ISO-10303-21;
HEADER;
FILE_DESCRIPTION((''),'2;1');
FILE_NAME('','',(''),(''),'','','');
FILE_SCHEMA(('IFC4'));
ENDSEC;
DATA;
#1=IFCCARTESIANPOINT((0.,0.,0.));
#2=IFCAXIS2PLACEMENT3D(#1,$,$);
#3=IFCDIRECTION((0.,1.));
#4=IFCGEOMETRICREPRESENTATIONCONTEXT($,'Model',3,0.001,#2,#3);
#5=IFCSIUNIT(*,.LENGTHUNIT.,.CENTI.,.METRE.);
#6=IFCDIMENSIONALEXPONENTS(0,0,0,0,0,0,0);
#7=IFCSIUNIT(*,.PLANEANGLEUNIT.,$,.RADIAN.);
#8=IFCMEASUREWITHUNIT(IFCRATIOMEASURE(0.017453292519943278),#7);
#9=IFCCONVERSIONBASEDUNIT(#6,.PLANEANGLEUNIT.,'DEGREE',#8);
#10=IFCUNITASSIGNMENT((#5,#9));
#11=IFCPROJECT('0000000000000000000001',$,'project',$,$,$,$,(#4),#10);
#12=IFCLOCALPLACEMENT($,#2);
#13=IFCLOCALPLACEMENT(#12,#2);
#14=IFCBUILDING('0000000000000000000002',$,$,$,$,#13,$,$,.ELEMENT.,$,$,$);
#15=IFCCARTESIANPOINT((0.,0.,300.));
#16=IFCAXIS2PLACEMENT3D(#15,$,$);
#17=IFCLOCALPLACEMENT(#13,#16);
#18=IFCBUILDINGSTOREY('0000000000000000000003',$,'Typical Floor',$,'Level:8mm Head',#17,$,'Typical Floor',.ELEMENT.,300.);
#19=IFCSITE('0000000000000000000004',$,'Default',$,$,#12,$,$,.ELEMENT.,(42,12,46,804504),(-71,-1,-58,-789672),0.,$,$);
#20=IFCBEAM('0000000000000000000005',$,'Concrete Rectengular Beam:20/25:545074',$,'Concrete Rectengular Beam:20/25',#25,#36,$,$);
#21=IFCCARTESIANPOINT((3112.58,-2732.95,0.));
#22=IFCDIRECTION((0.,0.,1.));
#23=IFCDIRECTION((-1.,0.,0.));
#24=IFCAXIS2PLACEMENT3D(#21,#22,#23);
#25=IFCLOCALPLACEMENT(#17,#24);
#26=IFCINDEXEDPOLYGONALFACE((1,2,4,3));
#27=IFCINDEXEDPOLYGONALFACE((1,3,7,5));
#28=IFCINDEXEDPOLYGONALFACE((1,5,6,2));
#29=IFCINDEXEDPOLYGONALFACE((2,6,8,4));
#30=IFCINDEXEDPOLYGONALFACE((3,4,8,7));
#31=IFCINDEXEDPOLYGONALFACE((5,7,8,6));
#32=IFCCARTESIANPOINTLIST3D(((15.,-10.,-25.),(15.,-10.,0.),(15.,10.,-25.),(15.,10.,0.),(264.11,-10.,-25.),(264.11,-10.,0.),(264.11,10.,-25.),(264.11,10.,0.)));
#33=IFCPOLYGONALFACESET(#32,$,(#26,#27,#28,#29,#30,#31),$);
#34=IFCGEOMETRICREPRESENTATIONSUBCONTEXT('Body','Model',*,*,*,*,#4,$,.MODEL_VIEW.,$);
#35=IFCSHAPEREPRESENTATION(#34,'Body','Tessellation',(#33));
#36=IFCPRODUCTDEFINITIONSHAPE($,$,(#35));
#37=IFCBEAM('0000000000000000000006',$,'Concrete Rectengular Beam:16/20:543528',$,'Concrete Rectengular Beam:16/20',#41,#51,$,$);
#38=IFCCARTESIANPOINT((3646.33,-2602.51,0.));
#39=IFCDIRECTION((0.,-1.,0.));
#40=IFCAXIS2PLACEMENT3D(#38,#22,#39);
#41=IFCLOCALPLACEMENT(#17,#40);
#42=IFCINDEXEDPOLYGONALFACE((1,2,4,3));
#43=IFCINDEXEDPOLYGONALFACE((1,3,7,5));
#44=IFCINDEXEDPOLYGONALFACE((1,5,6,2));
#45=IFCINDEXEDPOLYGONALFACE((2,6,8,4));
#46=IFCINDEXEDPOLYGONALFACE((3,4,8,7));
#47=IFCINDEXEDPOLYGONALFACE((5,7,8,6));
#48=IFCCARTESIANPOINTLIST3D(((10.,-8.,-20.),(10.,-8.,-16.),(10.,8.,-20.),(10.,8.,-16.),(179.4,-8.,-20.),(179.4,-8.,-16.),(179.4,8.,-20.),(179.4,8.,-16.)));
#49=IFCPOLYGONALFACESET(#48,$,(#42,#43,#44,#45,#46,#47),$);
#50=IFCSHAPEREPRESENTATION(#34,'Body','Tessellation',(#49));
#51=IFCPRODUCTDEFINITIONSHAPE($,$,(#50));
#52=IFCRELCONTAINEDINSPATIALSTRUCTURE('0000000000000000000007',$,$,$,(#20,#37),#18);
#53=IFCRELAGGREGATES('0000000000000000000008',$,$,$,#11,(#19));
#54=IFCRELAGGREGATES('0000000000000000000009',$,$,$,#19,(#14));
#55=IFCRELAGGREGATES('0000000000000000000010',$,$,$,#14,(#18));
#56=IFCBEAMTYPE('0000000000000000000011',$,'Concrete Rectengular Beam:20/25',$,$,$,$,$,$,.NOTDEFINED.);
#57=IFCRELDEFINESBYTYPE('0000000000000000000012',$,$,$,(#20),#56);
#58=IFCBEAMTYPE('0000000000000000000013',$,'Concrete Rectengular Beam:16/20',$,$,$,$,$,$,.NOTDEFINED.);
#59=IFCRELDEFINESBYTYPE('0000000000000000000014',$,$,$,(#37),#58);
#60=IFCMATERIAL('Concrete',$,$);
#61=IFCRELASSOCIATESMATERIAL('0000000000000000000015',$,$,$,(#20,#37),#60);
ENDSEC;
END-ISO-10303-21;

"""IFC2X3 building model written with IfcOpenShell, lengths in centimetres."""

from ifc_helpers import new_model, entity, si_unit, converted_unit, direction, frame, frame_2d, origin, place, context, subcontext, project, spatial, rectangle, extrude, material, type_object, element, save


model = new_model("IFC2X3")

# Units and contexts
model_context = context("Model", 3, precision=0.001, world=origin(), true_north=direction((0.0, 1.0)))
body_context = subcontext(model_context, "Body", "Model", "MODEL_VIEW")
ifc_project = project(units=[si_unit("LENGTHUNIT", "METRE", prefix="CENTI"), converted_unit("PLANEANGLEUNIT", "DEGREE", entity("IfcRatioMeasure", 0.017453292519943278), si_unit("PLANEANGLEUNIT", "RADIAN"), dimensions=[0, 0, 0, 0, 0, 0, 0])], contexts=[model_context])

# Site, building, storey
site_placement = place(None, origin())
site = spatial("IfcSite", under=ifc_project, at=site_placement, Name="Default", CompositionType="ELEMENT", RefLatitude=(42, 12, 46, 804504), RefLongitude=(-71, -1, -58, -789672), RefElevation=0.0)
building_placement = place(site_placement, origin())
building = spatial("IfcBuilding", under=site, at=building_placement, CompositionType="ELEMENT")
storey_placement = place(building_placement, frame((0.0, 0.0, 300.0)))
storey = spatial("IfcBuildingStorey", under=building, at=storey_placement, Name="Typical Floor", ObjectType="Level:8mm Head", LongName="Typical Floor", CompositionType="ELEMENT", Elevation=300.0)

# Beams
ifc_material = material(Name="Concrete")
beam_type_1 = type_object("IfcBeamType", Name="Concrete Rectengular Beam:20/25", PredefinedType="NOTDEFINED")
beam_1_placement = place(storey_placement, frame((3112.58, -2732.95, 0.0), z_axis=(0.0, 0.0, 1.0), x_axis=(-1.0, 0.0, 0.0)))
element("IfcBeam", 1, at=beam_1_placement, inside=storey, type_object=beam_type_1, material=ifc_material, Name="Concrete Rectengular Beam:20/25:545074", ObjectType="Concrete Rectengular Beam:20/25", context=body_context, shape_type="SweptSolid", body=[
    extrude(rectangle(XDim=25.0, YDim=20.0, at=frame_2d((0.0, 0.0), x_axis=(1.0, 0.0))), frame((15.0, 0.0, -12.5), z_axis=(1.0, 0.0, 0.0), x_axis=(0.0, 0.0, -1.0)), (0.0, 0.0, 1.0), 249.11),
])
beam_type_2 = type_object("IfcBeamType", Name="Concrete Rectengular Beam:16/20", PredefinedType="NOTDEFINED")
beam_2_placement = place(storey_placement, frame((3646.33, -2602.51, 0.0), z_axis=(0.0, 0.0, 1.0), x_axis=(0.0, -1.0, 0.0)))
element("IfcBeam", 2, at=beam_2_placement, inside=storey, type_object=beam_type_2, material=ifc_material, Name="Concrete Rectengular Beam:16/20:543528", ObjectType="Concrete Rectengular Beam:16/20", context=body_context, shape_type="SweptSolid", body=[
    extrude(rectangle(XDim=4.0, YDim=16.0, at=frame_2d((0.0, 0.0), x_axis=(1.0, 0.0))), frame((10.0, 0.0, -18.0), z_axis=(1.0, 0.0, 0.0), x_axis=(0.0, 0.0, -1.0)), (0.0, 0.0, 1.0), 169.4),
])

save(model, "model.ifc")
